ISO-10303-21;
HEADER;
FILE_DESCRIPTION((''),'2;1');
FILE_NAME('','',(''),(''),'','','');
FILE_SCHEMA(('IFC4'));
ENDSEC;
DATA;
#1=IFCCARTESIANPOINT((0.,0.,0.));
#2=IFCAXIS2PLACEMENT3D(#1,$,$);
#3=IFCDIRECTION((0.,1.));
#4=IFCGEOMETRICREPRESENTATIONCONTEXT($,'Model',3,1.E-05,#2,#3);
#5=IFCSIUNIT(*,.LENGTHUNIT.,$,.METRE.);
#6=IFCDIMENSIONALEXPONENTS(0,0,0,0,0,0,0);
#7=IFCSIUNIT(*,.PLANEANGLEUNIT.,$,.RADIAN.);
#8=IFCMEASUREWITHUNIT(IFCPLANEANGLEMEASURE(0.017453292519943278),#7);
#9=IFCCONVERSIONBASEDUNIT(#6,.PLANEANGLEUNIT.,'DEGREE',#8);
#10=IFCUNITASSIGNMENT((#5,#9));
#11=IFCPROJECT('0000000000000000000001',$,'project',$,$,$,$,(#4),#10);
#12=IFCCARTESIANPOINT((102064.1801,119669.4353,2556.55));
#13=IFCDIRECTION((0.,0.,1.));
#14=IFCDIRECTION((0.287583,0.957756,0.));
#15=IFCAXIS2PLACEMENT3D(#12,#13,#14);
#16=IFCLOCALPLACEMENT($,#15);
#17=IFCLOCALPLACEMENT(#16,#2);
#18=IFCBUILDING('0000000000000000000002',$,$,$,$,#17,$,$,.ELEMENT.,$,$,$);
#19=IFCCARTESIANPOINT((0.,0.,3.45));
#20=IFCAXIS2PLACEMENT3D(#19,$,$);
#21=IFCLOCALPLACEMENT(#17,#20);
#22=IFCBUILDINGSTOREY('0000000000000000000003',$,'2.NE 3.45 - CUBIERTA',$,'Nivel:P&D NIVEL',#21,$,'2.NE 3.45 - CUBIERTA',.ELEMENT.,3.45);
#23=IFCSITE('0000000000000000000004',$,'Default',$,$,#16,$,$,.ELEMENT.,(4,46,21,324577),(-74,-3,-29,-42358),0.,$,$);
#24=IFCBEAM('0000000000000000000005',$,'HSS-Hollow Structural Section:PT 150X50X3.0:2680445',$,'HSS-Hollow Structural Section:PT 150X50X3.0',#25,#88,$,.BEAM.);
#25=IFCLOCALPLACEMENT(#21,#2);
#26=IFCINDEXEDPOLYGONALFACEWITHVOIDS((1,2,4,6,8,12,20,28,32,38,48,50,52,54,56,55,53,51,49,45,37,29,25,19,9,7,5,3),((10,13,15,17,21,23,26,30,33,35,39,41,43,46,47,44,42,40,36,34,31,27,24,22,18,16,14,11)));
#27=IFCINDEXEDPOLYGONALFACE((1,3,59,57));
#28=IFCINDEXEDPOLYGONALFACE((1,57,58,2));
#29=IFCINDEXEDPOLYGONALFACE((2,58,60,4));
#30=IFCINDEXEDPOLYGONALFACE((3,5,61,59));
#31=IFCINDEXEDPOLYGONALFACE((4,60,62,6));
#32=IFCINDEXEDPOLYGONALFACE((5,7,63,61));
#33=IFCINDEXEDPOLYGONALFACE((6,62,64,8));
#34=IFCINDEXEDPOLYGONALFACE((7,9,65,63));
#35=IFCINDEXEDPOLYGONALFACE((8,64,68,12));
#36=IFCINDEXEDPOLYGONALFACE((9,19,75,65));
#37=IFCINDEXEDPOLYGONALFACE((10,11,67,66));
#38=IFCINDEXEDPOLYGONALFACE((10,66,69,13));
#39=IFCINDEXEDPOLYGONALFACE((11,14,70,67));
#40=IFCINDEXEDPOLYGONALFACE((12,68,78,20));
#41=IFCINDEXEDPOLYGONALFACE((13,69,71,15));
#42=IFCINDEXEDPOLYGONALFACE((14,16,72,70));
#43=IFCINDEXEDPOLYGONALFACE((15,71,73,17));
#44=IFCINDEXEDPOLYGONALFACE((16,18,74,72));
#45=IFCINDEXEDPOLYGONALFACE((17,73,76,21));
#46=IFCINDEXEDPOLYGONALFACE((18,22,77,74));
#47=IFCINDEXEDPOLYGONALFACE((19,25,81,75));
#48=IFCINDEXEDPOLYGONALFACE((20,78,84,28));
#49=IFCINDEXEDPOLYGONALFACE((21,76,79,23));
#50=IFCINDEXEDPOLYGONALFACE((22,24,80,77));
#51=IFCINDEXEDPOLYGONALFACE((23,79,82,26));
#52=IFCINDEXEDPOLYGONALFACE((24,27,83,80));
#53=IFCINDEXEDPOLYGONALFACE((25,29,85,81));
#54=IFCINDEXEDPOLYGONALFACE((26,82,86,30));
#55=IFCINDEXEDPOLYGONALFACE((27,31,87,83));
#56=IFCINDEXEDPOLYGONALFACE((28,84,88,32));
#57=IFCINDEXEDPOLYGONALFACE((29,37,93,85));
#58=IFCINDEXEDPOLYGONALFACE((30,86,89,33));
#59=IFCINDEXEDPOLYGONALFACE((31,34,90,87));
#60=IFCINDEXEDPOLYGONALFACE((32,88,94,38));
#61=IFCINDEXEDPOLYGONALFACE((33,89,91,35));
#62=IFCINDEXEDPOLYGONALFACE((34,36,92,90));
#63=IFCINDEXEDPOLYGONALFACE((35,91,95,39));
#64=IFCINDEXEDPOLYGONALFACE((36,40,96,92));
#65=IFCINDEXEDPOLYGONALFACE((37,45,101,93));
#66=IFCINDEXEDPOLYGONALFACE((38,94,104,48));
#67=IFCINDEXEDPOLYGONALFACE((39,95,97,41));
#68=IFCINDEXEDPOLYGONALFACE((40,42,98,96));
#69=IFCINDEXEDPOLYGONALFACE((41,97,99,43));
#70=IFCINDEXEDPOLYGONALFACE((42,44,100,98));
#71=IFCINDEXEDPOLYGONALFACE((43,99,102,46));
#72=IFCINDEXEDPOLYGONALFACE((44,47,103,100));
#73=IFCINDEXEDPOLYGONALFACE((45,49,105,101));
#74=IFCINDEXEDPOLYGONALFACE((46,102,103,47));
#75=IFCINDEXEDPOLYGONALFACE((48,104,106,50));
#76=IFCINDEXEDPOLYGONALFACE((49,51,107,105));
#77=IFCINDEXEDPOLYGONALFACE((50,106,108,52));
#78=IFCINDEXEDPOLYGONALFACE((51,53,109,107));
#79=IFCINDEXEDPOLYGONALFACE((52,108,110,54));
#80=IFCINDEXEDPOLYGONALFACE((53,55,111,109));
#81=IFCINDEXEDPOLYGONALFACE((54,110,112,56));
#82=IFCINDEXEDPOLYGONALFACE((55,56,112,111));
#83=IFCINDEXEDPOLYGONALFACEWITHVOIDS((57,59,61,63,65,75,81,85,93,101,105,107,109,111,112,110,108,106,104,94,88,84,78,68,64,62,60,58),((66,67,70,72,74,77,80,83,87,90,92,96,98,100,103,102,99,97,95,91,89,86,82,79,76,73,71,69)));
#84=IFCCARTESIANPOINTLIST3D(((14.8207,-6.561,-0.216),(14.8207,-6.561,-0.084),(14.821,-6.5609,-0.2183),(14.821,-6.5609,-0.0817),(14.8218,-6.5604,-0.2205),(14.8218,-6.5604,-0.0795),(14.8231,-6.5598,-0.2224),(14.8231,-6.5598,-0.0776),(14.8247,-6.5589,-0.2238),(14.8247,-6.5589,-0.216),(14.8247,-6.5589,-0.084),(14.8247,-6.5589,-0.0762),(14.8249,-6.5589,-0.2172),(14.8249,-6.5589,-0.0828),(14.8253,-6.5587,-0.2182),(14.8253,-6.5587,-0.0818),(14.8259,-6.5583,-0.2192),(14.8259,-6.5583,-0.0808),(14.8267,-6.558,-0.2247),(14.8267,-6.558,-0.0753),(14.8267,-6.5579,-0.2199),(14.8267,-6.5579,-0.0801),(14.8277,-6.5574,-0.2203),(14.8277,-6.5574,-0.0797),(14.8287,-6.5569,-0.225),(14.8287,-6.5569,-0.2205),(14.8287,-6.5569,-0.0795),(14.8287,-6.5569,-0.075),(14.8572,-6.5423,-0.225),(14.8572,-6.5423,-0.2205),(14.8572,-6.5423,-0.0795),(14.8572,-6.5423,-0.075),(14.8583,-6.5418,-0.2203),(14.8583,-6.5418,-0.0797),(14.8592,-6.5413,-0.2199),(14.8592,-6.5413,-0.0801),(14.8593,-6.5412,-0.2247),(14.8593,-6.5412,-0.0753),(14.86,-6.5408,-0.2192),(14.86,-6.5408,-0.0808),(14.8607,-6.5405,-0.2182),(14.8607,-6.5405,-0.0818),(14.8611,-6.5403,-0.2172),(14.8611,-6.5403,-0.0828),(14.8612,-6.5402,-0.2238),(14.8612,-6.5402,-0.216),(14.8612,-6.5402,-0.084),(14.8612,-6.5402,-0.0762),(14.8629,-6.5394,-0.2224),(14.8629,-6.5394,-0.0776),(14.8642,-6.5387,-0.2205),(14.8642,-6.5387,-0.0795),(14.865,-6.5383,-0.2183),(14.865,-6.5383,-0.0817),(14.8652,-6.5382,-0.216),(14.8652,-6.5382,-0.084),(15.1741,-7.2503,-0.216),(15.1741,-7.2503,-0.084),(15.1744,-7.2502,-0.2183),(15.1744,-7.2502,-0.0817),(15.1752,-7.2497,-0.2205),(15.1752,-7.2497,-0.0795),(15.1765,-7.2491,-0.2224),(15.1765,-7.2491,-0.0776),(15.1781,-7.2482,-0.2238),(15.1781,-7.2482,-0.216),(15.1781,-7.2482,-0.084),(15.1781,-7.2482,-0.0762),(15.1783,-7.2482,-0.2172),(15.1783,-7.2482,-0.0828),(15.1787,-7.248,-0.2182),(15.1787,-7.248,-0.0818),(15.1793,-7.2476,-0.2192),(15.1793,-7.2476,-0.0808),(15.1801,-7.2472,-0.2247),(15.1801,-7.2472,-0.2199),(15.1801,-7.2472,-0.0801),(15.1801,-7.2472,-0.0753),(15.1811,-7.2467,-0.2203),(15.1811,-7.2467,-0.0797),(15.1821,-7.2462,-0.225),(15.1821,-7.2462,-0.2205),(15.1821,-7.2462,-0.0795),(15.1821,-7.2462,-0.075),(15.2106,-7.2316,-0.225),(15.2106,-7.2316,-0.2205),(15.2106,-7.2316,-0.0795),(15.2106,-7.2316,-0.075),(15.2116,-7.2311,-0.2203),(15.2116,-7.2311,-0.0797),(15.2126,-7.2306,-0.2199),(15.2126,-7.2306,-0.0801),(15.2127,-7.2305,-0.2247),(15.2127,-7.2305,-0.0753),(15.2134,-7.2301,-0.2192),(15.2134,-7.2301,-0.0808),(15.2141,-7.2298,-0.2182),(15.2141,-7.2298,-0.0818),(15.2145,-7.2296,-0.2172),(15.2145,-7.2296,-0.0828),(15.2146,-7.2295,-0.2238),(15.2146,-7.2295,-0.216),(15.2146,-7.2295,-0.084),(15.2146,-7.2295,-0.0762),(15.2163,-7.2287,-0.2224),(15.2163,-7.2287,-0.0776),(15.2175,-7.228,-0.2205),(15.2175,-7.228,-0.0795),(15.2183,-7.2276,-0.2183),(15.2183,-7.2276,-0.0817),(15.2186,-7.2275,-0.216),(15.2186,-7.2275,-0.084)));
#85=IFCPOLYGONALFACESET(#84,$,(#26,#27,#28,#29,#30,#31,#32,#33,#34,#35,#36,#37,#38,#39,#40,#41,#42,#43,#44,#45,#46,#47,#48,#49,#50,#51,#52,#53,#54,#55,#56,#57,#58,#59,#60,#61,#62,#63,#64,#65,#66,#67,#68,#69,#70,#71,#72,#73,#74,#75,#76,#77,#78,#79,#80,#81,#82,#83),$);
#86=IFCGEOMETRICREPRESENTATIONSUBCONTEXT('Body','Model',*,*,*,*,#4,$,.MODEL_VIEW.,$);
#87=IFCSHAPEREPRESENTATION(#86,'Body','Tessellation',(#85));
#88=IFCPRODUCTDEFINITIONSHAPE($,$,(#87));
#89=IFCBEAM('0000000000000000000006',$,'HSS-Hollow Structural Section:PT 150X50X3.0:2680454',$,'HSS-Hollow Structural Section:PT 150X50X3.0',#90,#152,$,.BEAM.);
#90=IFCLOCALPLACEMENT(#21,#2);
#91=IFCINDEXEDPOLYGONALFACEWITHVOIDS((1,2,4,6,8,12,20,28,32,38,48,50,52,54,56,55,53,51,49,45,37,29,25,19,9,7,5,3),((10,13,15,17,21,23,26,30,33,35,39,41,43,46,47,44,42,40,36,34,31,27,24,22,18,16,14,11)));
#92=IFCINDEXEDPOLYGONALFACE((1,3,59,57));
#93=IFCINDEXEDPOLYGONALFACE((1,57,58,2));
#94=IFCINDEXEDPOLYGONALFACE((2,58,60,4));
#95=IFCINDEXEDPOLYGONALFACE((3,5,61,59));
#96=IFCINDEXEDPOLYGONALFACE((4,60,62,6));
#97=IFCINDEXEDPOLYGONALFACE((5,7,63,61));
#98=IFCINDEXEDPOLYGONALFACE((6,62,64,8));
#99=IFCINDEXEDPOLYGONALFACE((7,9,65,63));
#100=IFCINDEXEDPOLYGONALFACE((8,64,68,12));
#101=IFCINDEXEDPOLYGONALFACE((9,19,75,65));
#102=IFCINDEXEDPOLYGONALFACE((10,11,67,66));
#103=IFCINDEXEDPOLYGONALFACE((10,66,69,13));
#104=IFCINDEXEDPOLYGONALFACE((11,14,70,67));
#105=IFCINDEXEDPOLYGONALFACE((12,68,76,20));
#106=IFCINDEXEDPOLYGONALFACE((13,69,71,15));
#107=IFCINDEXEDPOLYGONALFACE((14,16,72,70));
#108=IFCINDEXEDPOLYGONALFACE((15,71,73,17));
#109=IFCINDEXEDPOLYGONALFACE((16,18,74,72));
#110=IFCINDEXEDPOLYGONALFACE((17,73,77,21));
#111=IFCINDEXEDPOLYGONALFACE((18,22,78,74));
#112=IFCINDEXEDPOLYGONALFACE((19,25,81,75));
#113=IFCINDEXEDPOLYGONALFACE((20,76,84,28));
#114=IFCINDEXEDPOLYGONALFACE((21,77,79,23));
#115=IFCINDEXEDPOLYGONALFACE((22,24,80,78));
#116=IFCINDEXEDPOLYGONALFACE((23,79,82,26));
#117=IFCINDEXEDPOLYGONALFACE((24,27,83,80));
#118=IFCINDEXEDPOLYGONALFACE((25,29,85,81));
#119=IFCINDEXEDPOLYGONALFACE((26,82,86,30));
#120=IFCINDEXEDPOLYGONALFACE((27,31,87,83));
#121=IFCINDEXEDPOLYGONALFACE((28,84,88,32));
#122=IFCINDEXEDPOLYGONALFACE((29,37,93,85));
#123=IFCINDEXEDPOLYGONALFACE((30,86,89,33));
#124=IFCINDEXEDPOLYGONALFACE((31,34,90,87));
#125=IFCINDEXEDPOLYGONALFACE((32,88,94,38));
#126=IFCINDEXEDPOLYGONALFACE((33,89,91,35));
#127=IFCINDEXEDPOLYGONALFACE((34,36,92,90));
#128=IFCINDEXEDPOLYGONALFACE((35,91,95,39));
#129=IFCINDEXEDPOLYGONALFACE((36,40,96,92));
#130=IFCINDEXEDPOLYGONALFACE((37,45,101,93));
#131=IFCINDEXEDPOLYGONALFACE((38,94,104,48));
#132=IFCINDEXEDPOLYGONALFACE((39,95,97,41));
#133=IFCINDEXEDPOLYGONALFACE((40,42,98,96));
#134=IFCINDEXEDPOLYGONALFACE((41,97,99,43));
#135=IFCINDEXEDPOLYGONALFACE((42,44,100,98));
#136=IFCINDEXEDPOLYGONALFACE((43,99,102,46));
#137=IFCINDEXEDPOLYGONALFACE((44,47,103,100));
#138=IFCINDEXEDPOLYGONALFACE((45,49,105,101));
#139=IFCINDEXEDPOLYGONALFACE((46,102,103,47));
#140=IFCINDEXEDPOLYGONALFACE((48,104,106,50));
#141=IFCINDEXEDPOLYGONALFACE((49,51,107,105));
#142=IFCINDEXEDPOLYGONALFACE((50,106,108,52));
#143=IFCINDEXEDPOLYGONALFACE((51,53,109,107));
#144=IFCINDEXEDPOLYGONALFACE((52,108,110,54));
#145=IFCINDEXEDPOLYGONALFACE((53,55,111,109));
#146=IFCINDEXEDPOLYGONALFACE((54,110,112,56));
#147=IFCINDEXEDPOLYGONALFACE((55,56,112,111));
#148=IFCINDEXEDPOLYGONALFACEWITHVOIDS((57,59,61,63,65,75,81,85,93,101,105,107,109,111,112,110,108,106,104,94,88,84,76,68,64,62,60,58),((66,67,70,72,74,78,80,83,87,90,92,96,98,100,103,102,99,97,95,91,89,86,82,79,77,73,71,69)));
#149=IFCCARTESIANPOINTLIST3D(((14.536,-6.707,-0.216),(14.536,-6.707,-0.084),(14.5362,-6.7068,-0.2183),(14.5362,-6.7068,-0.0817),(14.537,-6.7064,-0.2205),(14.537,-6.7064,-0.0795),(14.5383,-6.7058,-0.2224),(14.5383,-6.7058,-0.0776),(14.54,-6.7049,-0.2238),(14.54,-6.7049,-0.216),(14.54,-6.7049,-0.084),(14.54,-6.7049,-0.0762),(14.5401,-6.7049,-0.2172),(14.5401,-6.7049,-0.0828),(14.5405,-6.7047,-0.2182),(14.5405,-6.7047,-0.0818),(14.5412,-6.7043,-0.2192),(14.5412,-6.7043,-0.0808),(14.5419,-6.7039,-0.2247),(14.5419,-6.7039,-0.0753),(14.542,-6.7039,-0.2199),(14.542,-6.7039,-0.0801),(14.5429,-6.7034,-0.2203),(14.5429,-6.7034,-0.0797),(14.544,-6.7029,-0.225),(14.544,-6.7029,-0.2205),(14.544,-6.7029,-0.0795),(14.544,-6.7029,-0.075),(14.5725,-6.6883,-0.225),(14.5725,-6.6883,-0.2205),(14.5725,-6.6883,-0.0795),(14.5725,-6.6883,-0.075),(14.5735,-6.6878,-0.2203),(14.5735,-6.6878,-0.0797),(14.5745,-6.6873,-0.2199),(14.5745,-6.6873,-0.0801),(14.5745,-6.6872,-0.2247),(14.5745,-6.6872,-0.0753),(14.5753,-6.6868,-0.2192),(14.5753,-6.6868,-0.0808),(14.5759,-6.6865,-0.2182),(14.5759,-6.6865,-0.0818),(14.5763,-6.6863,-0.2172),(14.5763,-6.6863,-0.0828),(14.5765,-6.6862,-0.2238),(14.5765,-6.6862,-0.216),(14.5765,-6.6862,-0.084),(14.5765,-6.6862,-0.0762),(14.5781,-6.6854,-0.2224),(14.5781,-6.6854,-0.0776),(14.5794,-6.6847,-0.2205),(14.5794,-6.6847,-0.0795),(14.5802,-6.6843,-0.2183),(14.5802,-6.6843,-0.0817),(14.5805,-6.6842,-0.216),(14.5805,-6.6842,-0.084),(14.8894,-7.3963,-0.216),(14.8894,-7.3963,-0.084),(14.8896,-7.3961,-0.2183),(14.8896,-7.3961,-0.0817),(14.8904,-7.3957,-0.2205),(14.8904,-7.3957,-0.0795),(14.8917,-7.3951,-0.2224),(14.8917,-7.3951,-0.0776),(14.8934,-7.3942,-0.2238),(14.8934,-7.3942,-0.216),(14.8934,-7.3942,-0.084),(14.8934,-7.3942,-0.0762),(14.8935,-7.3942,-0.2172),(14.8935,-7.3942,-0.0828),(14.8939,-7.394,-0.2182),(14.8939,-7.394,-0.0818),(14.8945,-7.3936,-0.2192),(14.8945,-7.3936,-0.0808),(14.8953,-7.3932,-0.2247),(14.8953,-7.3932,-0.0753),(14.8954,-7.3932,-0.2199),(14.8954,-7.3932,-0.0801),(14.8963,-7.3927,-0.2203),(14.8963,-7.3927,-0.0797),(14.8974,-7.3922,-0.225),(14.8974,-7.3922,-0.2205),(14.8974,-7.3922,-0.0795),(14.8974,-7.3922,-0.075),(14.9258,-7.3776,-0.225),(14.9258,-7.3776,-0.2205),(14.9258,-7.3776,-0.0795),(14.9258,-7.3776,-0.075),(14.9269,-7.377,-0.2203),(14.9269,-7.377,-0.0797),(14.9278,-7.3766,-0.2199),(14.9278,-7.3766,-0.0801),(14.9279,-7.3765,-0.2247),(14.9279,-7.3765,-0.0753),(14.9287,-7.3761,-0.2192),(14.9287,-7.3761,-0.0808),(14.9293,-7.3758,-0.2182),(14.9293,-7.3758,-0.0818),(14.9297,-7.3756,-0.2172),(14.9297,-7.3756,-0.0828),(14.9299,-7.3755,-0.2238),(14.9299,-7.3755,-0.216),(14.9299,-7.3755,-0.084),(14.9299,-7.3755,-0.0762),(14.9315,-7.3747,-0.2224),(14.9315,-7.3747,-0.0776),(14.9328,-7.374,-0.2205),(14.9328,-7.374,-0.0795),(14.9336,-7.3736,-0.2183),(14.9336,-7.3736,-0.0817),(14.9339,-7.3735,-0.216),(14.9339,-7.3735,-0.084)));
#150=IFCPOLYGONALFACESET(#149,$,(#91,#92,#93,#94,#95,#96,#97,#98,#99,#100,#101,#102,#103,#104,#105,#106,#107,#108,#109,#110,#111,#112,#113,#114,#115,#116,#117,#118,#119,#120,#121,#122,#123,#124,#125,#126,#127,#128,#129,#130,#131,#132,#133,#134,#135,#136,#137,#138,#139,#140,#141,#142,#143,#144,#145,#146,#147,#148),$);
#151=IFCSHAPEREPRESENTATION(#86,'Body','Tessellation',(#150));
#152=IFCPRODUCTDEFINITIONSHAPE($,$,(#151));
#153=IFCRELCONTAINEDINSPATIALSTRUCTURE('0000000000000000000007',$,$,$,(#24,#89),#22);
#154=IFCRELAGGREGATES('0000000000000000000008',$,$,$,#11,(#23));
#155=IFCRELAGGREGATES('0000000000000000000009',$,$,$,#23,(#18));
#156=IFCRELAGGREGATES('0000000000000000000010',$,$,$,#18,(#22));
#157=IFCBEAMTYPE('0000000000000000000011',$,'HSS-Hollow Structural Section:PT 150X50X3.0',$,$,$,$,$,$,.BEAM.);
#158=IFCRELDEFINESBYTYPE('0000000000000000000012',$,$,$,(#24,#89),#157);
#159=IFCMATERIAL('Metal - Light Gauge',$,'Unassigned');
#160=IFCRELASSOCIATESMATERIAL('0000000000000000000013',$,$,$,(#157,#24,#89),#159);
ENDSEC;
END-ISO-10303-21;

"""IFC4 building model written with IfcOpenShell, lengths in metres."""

from ifc_helpers import new_model, entity, si_unit, converted_unit, direction, frame, origin, place, context, subcontext, project, spatial, line, arc, indexed_curve, outline, extrude, source, transform, mapped, material, type_object, type_shapes, element, save


model = new_model("IFC4")

# Units and contexts
model_context = context("Model", 3, precision=1e-05, world=origin(), true_north=direction((0.0, 1.0)))
body_context = subcontext(model_context, "Body", "Model", "MODEL_VIEW")
ifc_project = project(units=[si_unit("LENGTHUNIT", "METRE"), converted_unit("PLANEANGLEUNIT", "DEGREE", entity("IfcPlaneAngleMeasure", 0.017453292519943278), si_unit("PLANEANGLEUNIT", "RADIAN"), dimensions=[0, 0, 0, 0, 0, 0, 0])], contexts=[model_context])

# Site, building, storey
site_placement = place(None, frame((102064.1801, 119669.4353, 2556.55), z_axis=(0.0, 0.0, 1.0), x_axis=(0.287583, 0.957756, 0.0)))
site = spatial("IfcSite", under=ifc_project, at=site_placement, Name="Default", CompositionType="ELEMENT", RefLatitude=(4, 46, 21, 324577), RefLongitude=(-74, -3, -29, -42358), RefElevation=0.0)
building_placement = place(site_placement, origin())
building = spatial("IfcBuilding", under=site, at=building_placement, CompositionType="ELEMENT")
storey_placement = place(building_placement, frame((0.0, 0.0, 3.45)))
storey = spatial("IfcBuildingStorey", under=building, at=storey_placement, Name="2.NE 3.45 - CUBIERTA", ObjectType="Nivel:P&D NIVEL", LongName="2.NE 3.45 - CUBIERTA", CompositionType="ELEMENT", Elevation=3.45)

# Beams
ifc_material_1 = material(Name="Metal - Light Gauge", Category="Unassigned")
beam_type_1 = type_object("IfcBeamType", Name="HSS-Hollow Structural Section:PT 150X50X3.0", PredefinedType="BEAM", material=ifc_material_1)
shared_shape_1 = source(origin(), body_context, "Body", "SweptSolid", [
    extrude(outline(indexed_curve([(-0.025, -0.066), (-0.0224, -0.0724), (-0.016, -0.075), (0.016, -0.075), (0.0224, -0.0724), (0.025, -0.066), (0.025, 0.066), (0.0224, 0.0724), (0.016, 0.075), (-0.016, 0.075), (-0.0224, 0.0724), (-0.025, 0.066)], segments=[arc(1, 2, 3), line(3, 4), arc(4, 5, 6), line(6, 7), arc(7, 8, 9), line(9, 10), arc(10, 11, 12), line(12, 1)], self_intersect=False), holes=[indexed_curve([(0.016, -0.0705), (-0.016, -0.0705), (-0.0192, -0.0692), (-0.0205, -0.066), (-0.0205, 0.066), (-0.0192, 0.0692), (-0.016, 0.0705), (0.016, 0.0705), (0.0192, 0.0692), (0.0205, 0.066), (0.0205, -0.066), (0.0192, -0.0692)], segments=[line(1, 2), arc(2, 3, 4), line(4, 5), arc(5, 6, 7), line(7, 8), arc(8, 9, 10), line(10, 11), arc(11, 12, 1)], self_intersect=False)]), frame((-0.3873, 0.0, 0.0), z_axis=(1.0, 0.0, 0.0), x_axis=(0.0, -1.0, 0.0)), (0.0, 0.0, 1.0), 0.7746),
])
type_shapes(beam_type_1, [shared_shape_1])
for number, where, z_axis, x_axis, name in (
    (1, (15.0197, -6.8942, -0.15), (0.0, 0.0, 1.0), (-0.456217, 0.889869, 0.0), "HSS-Hollow Structural Section:PT 150X50X3.0:2680445"),
    (2, (14.7349, -7.0402, -0.15), (0.0, 0.0, 1.0), (-0.456217, 0.889869, 0.0), "HSS-Hollow Structural Section:PT 150X50X3.0:2680454"),
):
    element("IfcBeam", number, at=place(storey_placement, frame(where, z_axis=z_axis, x_axis=x_axis)), inside=storey, type_object=beam_type_1, material=ifc_material_1, Name=name, ObjectType="HSS-Hollow Structural Section:PT 150X50X3.0", PredefinedType="BEAM", context=body_context, shape_type="MappedRepresentation", body=[
        mapped(shared_shape_1, transform((0.0, 0.0, 0.0), scale=1.0)),
    ])

save(model, "model.ifc")
